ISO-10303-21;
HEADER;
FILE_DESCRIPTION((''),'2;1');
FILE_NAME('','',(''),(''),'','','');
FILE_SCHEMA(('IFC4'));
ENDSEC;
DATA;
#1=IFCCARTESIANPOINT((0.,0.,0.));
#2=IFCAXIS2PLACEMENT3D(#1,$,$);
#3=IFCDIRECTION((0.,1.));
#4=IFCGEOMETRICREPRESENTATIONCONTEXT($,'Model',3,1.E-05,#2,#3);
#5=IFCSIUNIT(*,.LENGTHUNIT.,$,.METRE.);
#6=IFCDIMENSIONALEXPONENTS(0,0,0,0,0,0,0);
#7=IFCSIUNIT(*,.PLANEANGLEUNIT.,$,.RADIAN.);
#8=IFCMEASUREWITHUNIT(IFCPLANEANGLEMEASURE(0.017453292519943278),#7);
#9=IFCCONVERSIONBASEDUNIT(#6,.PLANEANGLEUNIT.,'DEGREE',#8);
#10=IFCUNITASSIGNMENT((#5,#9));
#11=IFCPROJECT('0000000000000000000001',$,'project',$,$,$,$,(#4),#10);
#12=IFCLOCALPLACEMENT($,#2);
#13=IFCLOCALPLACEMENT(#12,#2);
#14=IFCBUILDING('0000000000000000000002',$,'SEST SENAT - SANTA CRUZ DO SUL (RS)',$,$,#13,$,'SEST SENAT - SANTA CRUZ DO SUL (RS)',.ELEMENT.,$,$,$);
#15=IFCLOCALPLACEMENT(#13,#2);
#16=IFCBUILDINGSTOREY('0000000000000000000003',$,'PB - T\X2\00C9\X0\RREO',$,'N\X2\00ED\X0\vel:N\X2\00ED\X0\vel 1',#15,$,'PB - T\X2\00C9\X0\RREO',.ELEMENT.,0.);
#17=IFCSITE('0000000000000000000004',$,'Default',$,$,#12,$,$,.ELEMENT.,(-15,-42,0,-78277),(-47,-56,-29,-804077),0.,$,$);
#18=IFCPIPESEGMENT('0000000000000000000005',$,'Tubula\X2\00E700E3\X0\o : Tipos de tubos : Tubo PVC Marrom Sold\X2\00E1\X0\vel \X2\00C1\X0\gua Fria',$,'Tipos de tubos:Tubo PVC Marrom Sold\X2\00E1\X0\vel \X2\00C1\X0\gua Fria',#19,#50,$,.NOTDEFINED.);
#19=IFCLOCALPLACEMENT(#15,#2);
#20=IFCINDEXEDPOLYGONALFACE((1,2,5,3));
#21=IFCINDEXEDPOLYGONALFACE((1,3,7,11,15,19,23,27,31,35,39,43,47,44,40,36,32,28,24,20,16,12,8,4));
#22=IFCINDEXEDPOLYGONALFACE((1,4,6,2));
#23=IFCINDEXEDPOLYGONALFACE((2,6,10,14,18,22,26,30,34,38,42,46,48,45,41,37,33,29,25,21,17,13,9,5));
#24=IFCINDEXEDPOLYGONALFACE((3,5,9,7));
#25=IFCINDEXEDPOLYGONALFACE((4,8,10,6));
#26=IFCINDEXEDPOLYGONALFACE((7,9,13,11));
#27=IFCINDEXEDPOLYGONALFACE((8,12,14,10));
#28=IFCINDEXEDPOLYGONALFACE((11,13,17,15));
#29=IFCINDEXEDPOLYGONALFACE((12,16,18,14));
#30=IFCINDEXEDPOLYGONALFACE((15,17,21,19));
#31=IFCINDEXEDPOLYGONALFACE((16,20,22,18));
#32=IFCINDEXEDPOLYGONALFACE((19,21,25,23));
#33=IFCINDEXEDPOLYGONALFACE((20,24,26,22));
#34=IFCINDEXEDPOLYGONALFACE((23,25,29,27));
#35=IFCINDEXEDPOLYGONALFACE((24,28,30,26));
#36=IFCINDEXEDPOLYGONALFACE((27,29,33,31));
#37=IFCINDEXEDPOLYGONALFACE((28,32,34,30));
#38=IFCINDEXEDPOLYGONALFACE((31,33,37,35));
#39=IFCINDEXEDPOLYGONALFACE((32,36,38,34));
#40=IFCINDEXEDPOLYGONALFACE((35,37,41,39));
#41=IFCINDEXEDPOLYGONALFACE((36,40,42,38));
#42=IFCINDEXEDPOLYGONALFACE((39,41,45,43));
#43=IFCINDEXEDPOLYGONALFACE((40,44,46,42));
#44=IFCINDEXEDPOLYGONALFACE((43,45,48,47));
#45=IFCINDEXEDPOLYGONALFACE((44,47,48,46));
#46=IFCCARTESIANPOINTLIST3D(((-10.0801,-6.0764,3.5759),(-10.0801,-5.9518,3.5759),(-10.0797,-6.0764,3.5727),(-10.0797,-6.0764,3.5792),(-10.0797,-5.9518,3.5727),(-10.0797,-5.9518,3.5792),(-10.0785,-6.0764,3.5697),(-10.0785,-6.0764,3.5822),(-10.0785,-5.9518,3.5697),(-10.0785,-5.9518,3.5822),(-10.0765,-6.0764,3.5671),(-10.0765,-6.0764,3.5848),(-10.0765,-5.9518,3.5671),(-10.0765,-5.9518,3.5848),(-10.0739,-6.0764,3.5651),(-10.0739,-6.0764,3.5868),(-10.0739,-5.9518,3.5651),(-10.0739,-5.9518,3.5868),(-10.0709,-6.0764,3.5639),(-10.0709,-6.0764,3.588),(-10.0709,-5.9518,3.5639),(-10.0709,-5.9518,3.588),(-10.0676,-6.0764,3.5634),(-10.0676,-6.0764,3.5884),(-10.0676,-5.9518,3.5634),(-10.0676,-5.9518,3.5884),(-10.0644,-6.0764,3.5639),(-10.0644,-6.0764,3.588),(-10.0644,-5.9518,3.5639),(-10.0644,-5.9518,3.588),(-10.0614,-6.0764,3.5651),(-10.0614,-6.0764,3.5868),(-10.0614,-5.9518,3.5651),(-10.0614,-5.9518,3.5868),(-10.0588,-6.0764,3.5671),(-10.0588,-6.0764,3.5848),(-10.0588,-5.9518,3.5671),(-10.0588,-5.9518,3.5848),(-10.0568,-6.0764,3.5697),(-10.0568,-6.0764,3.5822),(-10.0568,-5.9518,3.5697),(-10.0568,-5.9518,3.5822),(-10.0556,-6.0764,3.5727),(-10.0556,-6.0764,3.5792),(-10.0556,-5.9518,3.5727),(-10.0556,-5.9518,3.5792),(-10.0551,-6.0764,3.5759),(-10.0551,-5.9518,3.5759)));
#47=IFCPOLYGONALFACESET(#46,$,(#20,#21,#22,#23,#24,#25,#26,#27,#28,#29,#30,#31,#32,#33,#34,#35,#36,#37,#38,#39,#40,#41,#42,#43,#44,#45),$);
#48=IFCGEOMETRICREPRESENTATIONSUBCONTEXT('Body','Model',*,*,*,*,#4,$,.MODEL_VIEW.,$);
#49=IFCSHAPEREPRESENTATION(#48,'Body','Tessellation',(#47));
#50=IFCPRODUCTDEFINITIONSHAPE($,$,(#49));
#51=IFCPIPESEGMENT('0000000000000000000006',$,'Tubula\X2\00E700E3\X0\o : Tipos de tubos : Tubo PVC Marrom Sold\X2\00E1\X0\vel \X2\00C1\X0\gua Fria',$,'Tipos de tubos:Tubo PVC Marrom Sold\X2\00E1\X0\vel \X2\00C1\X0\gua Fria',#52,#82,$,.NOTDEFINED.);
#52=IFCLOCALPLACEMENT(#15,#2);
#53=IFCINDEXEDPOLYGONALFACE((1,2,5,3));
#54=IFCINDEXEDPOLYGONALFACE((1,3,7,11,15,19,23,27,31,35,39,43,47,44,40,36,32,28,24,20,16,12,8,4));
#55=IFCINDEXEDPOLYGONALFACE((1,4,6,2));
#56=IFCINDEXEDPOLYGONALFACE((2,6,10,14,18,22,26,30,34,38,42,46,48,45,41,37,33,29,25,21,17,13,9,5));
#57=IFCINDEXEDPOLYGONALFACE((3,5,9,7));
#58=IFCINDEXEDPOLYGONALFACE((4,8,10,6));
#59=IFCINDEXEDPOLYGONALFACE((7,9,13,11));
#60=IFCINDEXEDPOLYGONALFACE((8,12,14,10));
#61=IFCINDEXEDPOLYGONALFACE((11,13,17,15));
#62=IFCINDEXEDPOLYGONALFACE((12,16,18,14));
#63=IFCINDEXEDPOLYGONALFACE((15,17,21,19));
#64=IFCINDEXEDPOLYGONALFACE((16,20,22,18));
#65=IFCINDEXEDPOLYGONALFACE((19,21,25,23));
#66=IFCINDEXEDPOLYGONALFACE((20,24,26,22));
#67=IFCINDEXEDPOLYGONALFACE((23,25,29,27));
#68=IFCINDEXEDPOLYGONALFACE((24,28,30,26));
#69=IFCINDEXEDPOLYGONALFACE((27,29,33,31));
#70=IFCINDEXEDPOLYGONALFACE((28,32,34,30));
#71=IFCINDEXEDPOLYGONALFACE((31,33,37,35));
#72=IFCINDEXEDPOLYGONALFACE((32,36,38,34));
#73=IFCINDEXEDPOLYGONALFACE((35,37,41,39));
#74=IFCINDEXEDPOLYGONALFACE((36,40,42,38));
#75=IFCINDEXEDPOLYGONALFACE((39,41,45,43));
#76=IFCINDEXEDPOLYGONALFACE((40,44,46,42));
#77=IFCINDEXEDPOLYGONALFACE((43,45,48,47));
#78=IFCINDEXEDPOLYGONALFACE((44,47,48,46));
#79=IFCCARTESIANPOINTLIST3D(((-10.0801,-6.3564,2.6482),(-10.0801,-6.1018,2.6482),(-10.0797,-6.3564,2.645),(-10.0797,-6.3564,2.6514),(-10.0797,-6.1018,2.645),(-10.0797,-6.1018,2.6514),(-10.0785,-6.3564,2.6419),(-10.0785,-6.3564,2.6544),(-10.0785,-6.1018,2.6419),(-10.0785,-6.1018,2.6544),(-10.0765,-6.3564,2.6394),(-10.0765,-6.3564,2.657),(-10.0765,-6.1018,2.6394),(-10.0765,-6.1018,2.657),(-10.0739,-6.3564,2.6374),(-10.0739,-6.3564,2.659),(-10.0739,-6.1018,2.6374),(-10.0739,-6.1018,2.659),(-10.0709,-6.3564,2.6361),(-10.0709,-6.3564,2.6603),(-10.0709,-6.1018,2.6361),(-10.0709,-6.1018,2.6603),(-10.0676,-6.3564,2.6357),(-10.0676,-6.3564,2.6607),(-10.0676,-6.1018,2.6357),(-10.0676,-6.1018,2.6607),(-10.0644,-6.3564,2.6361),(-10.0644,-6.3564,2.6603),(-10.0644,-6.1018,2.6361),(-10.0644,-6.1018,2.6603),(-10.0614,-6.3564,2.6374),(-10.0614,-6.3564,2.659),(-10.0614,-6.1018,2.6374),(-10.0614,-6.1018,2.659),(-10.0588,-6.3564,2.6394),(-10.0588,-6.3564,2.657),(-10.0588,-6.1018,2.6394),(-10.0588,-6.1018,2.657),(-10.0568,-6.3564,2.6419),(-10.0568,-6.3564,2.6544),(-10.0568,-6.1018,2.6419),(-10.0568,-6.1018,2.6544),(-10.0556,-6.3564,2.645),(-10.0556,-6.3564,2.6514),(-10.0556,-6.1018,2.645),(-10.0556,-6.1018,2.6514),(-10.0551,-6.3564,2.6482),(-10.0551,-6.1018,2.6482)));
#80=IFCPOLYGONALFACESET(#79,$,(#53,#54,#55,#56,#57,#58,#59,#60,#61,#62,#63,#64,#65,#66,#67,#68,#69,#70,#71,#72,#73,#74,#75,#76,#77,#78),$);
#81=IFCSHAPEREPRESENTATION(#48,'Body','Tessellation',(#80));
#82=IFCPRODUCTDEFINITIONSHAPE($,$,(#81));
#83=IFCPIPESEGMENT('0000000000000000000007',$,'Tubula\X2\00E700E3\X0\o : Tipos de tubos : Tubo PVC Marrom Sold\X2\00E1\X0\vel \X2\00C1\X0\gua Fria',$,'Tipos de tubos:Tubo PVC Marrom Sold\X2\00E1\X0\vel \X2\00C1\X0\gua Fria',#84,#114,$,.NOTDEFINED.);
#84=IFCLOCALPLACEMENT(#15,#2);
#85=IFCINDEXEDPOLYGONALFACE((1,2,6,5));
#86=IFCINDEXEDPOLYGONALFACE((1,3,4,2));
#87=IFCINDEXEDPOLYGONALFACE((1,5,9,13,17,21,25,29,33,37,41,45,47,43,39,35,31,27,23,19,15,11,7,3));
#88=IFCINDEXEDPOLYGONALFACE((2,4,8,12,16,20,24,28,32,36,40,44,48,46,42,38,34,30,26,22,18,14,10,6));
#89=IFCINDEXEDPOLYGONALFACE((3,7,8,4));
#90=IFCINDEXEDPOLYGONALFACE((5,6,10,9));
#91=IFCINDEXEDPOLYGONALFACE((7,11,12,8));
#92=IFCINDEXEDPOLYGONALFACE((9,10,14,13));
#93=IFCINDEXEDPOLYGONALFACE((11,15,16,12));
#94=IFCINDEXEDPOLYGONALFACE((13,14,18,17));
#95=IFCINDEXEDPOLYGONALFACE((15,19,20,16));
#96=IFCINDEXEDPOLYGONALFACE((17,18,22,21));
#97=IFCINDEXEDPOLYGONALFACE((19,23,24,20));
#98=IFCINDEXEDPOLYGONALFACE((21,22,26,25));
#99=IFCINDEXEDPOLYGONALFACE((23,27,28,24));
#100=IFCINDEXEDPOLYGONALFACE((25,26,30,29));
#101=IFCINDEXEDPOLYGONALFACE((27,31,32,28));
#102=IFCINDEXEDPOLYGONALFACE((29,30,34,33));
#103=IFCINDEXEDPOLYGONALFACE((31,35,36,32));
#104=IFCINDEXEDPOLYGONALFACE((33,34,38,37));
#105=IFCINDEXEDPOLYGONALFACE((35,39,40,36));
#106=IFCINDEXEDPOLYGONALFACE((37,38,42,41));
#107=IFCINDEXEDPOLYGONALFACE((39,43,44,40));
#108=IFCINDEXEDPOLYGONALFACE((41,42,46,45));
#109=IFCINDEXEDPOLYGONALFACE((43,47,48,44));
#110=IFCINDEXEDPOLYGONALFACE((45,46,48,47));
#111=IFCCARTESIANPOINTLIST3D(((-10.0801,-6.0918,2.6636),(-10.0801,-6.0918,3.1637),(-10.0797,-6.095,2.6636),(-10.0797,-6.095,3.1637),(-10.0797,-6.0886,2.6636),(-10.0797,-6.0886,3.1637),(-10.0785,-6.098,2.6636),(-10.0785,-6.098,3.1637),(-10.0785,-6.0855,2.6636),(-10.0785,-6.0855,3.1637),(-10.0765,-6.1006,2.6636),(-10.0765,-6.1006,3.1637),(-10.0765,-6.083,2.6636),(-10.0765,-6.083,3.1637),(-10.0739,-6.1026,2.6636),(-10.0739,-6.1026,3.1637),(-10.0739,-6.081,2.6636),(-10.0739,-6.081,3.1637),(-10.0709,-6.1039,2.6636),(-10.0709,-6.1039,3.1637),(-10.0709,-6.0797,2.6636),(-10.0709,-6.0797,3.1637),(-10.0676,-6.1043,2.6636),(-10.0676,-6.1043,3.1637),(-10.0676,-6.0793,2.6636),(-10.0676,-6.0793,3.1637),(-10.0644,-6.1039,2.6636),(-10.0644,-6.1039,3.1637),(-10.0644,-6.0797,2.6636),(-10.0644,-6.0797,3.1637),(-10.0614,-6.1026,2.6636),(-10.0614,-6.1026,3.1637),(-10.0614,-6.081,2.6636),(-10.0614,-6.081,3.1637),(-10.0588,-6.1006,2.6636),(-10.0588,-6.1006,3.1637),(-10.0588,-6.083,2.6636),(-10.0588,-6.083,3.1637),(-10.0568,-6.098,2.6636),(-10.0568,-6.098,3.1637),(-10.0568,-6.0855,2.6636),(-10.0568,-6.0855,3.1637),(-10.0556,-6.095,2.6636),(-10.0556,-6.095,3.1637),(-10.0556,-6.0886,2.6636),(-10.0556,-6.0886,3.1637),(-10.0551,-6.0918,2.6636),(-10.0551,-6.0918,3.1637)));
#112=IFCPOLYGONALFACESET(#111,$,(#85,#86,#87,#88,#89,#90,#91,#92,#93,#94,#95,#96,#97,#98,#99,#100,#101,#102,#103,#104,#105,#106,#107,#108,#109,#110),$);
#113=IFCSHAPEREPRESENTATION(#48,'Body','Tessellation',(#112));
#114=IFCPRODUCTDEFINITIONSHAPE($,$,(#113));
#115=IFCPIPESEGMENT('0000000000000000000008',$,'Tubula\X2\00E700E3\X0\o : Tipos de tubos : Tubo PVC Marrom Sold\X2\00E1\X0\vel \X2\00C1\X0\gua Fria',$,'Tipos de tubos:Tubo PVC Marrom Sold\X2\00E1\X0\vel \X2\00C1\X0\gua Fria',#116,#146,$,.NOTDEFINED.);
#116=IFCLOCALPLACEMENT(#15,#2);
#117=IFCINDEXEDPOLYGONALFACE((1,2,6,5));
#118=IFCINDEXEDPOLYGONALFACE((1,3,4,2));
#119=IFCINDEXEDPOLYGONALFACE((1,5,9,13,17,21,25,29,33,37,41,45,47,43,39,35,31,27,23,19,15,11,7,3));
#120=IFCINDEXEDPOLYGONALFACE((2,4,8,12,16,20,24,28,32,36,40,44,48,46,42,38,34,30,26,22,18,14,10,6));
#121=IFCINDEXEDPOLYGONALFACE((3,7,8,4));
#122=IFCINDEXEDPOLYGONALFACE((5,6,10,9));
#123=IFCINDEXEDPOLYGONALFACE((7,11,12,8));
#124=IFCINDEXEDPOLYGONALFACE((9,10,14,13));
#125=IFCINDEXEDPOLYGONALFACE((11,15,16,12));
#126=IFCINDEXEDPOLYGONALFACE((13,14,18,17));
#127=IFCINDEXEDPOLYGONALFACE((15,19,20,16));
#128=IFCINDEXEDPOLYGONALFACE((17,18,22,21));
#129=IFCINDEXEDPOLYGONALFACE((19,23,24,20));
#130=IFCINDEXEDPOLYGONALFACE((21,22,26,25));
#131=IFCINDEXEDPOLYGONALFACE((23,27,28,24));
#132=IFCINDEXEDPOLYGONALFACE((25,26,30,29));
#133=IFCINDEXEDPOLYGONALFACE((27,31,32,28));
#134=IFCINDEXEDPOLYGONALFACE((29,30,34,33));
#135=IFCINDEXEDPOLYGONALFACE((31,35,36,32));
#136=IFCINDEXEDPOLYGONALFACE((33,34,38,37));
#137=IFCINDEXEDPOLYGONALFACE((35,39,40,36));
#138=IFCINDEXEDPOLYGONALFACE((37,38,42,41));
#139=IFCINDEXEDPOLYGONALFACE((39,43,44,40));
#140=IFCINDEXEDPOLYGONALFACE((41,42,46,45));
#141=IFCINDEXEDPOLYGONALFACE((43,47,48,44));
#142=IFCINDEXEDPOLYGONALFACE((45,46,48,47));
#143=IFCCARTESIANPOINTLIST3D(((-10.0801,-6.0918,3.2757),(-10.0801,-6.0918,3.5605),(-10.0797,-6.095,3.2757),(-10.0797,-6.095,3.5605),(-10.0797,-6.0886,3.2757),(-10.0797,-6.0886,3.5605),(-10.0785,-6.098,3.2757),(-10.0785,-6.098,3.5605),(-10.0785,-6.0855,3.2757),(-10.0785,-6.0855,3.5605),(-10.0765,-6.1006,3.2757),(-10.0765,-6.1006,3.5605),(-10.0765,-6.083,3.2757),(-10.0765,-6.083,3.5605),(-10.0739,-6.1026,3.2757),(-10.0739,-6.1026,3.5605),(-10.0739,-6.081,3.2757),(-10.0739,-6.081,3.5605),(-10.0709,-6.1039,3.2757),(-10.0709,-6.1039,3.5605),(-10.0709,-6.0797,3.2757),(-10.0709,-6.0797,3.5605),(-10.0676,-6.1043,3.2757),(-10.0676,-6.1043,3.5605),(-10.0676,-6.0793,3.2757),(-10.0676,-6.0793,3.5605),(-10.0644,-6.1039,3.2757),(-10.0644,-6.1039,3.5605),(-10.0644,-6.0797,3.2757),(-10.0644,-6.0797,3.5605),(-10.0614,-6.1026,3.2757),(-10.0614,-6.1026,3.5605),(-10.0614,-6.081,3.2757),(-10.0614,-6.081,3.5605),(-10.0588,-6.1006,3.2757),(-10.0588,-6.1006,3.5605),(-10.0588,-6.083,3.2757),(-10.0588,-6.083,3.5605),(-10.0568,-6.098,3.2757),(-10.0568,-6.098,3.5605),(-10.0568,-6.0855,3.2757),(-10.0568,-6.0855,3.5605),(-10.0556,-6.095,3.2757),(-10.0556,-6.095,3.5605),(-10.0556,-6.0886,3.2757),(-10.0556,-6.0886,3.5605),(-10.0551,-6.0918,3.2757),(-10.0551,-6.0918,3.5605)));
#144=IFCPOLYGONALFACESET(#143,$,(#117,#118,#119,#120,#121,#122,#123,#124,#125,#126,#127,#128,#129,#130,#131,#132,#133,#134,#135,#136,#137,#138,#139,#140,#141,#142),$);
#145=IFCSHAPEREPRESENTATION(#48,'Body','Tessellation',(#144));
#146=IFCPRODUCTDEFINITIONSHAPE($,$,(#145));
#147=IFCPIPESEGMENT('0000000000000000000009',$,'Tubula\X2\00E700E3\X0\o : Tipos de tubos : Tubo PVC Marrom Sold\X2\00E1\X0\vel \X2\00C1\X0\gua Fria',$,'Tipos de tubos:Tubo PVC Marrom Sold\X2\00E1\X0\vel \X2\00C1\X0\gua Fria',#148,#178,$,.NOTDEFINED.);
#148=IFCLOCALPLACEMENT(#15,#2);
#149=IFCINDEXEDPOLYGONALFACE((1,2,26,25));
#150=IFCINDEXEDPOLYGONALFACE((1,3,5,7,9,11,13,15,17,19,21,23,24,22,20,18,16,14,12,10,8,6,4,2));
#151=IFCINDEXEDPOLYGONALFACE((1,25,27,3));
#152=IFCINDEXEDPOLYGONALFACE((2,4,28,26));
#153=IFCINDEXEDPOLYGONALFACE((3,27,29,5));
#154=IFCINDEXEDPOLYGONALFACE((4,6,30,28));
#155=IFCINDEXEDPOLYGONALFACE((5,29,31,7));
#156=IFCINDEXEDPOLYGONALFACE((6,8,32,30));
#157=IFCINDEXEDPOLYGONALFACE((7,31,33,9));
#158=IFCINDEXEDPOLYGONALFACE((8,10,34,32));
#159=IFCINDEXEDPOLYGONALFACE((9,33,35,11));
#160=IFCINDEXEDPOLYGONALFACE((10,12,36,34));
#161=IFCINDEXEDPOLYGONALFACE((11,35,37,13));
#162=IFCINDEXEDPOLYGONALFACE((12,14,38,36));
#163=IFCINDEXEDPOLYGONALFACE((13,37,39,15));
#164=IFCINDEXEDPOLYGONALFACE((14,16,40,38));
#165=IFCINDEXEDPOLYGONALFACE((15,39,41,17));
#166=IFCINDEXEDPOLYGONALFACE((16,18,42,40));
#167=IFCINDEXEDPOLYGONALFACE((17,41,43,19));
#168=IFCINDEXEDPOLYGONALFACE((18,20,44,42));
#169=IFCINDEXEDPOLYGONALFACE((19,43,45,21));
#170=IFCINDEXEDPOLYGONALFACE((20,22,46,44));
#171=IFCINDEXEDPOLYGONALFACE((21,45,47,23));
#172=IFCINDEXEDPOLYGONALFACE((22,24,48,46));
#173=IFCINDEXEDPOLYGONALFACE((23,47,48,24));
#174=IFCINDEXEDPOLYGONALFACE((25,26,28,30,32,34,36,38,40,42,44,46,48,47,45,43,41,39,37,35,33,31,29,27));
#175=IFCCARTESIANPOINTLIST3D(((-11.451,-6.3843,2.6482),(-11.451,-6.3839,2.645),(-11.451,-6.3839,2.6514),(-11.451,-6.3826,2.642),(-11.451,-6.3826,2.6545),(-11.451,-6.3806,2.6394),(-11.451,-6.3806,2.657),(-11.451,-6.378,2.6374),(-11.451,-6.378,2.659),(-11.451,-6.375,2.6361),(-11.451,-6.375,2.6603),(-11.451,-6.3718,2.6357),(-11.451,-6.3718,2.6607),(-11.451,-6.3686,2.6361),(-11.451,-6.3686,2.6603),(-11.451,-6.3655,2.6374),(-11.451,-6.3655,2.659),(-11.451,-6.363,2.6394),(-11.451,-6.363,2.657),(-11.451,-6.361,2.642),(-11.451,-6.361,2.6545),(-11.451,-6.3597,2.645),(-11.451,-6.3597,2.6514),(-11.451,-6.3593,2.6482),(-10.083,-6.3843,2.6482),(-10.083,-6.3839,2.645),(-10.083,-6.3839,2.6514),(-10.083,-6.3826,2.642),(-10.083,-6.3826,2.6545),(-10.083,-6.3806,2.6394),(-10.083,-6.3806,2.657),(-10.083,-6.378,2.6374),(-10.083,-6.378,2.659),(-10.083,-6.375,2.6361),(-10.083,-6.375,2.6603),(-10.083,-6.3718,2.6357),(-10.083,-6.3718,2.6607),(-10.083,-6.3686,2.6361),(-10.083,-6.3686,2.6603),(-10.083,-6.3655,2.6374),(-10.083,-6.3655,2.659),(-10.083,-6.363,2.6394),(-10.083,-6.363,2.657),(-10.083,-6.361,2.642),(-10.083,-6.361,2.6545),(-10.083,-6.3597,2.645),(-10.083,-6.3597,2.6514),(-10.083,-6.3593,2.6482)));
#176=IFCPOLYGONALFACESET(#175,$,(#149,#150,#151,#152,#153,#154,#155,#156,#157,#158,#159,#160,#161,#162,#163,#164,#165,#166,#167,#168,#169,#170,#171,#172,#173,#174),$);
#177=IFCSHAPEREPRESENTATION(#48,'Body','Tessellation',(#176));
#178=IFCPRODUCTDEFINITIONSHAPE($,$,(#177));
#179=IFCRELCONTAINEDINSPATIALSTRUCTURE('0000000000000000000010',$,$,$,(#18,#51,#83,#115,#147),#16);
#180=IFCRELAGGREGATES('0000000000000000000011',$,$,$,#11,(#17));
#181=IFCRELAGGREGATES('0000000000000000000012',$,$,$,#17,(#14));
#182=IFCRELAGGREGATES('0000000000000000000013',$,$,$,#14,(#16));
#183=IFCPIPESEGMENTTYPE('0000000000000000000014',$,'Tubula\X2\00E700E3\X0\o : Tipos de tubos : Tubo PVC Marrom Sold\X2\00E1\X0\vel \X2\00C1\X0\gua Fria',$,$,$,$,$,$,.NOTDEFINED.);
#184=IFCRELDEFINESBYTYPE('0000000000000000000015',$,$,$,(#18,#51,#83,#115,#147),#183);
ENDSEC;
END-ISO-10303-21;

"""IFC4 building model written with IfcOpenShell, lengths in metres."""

from ifc_helpers import new_model, entity, si_unit, converted_unit, direction, frame, origin, place, context, subcontext, project, spatial, arc, indexed_curve, outline, extrude, type_object, element, save


model = new_model("IFC4")

# Units and contexts
model_context = context("Model", 3, precision=1e-05, world=origin(), true_north=direction((0.0, 1.0)))
body_context = subcontext(model_context, "Body", "Model", "MODEL_VIEW")
ifc_project = project(units=[si_unit("LENGTHUNIT", "METRE"), converted_unit("PLANEANGLEUNIT", "DEGREE", entity("IfcPlaneAngleMeasure", 0.017453292519943278), si_unit("PLANEANGLEUNIT", "RADIAN"), dimensions=[0, 0, 0, 0, 0, 0, 0])], contexts=[model_context])

# Site, building, storey
site_placement = place(None, origin())
site = spatial("IfcSite", under=ifc_project, at=site_placement, Name="Default", CompositionType="ELEMENT", RefLatitude=(-15, -42, 0, -78277), RefLongitude=(-47, -56, -29, -804077), RefElevation=0.0)
building_placement = place(site_placement, origin())
building = spatial("IfcBuilding", under=site, at=building_placement, Name="SEST SENAT - SANTA CRUZ DO SUL (RS)", LongName="SEST SENAT - SANTA CRUZ DO SUL (RS)", CompositionType="ELEMENT")
storey_placement = place(building_placement, origin())
storey = spatial("IfcBuildingStorey", under=building, at=storey_placement, Name="PB - TÉRREO", ObjectType="Nível:Nível 1", LongName="PB - TÉRREO", CompositionType="ELEMENT", Elevation=0.0)

# Pipe segments
pipe_segment_type_1 = type_object("IfcPipeSegmentType", Name="Tubulação : Tipos de tubos : Tubo PVC Marrom Soldável Água Fria", PredefinedType="NOTDEFINED")
pipe_segment_1_placement = place(storey_placement, frame((-10.0817, -6.0764, 3.5618)))
element("IfcPipeSegment", 1, at=pipe_segment_1_placement, inside=storey, type_object=pipe_segment_type_1, Name="Tubulação : Tipos de tubos : Tubo PVC Marrom Soldável Água Fria", ObjectType="Tipos de tubos:Tubo PVC Marrom Soldável Água Fria", PredefinedType="NOTDEFINED", context=body_context, shape_type="SweptSolid", body=[
    extrude(outline(indexed_curve([(0.0125, 0.0), (0.0088, 0.0088), (0.0, 0.0125), (-0.0088, 0.0088), (-0.0125, 0.0), (-0.0088, -0.0088), (0.0, -0.0125), (0.0088, -0.0088)], segments=[arc(1, 2, 3), arc(3, 4, 5), arc(5, 6, 7), arc(7, 8, 1)], self_intersect=False)), frame((0.0141, 0.0, 0.0141), z_axis=(0.0, 1.0, 0.0), x_axis=(1.0, 0.0, 0.0)), (0.0, 0.0, 1.0), 0.1246),
])
pipe_segment_2_placement = place(storey_placement, frame((-10.0817, -6.3564, 2.6341)))
element("IfcPipeSegment", 2, at=pipe_segment_2_placement, inside=storey, type_object=pipe_segment_type_1, Name="Tubulação : Tipos de tubos : Tubo PVC Marrom Soldável Água Fria", ObjectType="Tipos de tubos:Tubo PVC Marrom Soldável Água Fria", PredefinedType="NOTDEFINED", context=body_context, shape_type="SweptSolid", body=[
    extrude(outline(indexed_curve([(0.0125, 0.0), (0.0088, 0.0088), (0.0, 0.0125), (-0.0088, 0.0088), (-0.0125, 0.0), (-0.0088, -0.0088), (0.0, -0.0125), (0.0088, -0.0088)], segments=[arc(1, 2, 3), arc(3, 4, 5), arc(5, 6, 7), arc(7, 8, 1)], self_intersect=False)), frame((0.0141, 0.0, 0.0141), z_axis=(0.0, 1.0, 0.0), x_axis=(1.0, 0.0, 0.0)), (0.0, 0.0, 1.0), 0.2546),
])
pipe_segment_3_placement = place(storey_placement, frame((-10.0817, -6.1059, 2.6636)))
element("IfcPipeSegment", 3, at=pipe_segment_3_placement, inside=storey, type_object=pipe_segment_type_1, Name="Tubulação : Tipos de tubos : Tubo PVC Marrom Soldável Água Fria", ObjectType="Tipos de tubos:Tubo PVC Marrom Soldável Água Fria", PredefinedType="NOTDEFINED", context=body_context, shape_type="SweptSolid", body=[
    extrude(outline(indexed_curve([(0.0125, 0.0), (0.0088, 0.0088), (0.0, 0.0125), (-0.0088, 0.0088), (-0.0125, 0.0), (-0.0088, -0.0088), (0.0, -0.0125), (0.0088, -0.0088)], segments=[arc(1, 2, 3), arc(3, 4, 5), arc(5, 6, 7), arc(7, 8, 1)], self_intersect=False)), frame((0.0141, 0.0141, 0.0), z_axis=(0.0, 0.0, 1.0), x_axis=(-1.0, 0.0, 0.0)), (0.0, 0.0, 1.0), 0.5001),
])
pipe_segment_4_placement = place(storey_placement, frame((-10.0817, -6.1059, 3.2757)))
element("IfcPipeSegment", 4, at=pipe_segment_4_placement, inside=storey, type_object=pipe_segment_type_1, Name="Tubulação : Tipos de tubos : Tubo PVC Marrom Soldável Água Fria", ObjectType="Tipos de tubos:Tubo PVC Marrom Soldável Água Fria", PredefinedType="NOTDEFINED", context=body_context, shape_type="SweptSolid", body=[
    extrude(outline(indexed_curve([(0.0125, 0.0), (0.0088, 0.0088), (0.0, 0.0125), (-0.0088, 0.0088), (-0.0125, 0.0), (-0.0088, -0.0088), (0.0, -0.0125), (0.0088, -0.0088)], segments=[arc(1, 2, 3), arc(3, 4, 5), arc(5, 6, 7), arc(7, 8, 1)], self_intersect=False)), frame((0.0141, 0.0141, 0.0)), (0.0, 0.0, 1.0), 0.2848),
])
pipe_segment_5_placement = place(storey_placement, frame((-11.451, -6.3859, 2.6623)))
element("IfcPipeSegment", 5, at=pipe_segment_5_placement, inside=storey, type_object=pipe_segment_type_1, Name="Tubulação : Tipos de tubos : Tubo PVC Marrom Soldável Água Fria", ObjectType="Tipos de tubos:Tubo PVC Marrom Soldável Água Fria", PredefinedType="NOTDEFINED", context=body_context, shape_type="SweptSolid", body=[
    extrude(outline(indexed_curve([(0.0125, 0.0), (0.0088, 0.0088), (0.0, 0.0125), (-0.0088, 0.0088), (-0.0125, 0.0), (-0.0088, -0.0088), (0.0, -0.0125), (0.0088, -0.0088)], segments=[arc(1, 2, 3), arc(3, 4, 5), arc(5, 6, 7), arc(7, 8, 1)], self_intersect=False)), frame((0.0, 0.0141, -0.0141), z_axis=(1.0, 0.0, 0.0), x_axis=(0.0, -1.0, 0.0)), (0.0, 0.0, 1.0), 1.368),
])

save(model, "model.ifc")
